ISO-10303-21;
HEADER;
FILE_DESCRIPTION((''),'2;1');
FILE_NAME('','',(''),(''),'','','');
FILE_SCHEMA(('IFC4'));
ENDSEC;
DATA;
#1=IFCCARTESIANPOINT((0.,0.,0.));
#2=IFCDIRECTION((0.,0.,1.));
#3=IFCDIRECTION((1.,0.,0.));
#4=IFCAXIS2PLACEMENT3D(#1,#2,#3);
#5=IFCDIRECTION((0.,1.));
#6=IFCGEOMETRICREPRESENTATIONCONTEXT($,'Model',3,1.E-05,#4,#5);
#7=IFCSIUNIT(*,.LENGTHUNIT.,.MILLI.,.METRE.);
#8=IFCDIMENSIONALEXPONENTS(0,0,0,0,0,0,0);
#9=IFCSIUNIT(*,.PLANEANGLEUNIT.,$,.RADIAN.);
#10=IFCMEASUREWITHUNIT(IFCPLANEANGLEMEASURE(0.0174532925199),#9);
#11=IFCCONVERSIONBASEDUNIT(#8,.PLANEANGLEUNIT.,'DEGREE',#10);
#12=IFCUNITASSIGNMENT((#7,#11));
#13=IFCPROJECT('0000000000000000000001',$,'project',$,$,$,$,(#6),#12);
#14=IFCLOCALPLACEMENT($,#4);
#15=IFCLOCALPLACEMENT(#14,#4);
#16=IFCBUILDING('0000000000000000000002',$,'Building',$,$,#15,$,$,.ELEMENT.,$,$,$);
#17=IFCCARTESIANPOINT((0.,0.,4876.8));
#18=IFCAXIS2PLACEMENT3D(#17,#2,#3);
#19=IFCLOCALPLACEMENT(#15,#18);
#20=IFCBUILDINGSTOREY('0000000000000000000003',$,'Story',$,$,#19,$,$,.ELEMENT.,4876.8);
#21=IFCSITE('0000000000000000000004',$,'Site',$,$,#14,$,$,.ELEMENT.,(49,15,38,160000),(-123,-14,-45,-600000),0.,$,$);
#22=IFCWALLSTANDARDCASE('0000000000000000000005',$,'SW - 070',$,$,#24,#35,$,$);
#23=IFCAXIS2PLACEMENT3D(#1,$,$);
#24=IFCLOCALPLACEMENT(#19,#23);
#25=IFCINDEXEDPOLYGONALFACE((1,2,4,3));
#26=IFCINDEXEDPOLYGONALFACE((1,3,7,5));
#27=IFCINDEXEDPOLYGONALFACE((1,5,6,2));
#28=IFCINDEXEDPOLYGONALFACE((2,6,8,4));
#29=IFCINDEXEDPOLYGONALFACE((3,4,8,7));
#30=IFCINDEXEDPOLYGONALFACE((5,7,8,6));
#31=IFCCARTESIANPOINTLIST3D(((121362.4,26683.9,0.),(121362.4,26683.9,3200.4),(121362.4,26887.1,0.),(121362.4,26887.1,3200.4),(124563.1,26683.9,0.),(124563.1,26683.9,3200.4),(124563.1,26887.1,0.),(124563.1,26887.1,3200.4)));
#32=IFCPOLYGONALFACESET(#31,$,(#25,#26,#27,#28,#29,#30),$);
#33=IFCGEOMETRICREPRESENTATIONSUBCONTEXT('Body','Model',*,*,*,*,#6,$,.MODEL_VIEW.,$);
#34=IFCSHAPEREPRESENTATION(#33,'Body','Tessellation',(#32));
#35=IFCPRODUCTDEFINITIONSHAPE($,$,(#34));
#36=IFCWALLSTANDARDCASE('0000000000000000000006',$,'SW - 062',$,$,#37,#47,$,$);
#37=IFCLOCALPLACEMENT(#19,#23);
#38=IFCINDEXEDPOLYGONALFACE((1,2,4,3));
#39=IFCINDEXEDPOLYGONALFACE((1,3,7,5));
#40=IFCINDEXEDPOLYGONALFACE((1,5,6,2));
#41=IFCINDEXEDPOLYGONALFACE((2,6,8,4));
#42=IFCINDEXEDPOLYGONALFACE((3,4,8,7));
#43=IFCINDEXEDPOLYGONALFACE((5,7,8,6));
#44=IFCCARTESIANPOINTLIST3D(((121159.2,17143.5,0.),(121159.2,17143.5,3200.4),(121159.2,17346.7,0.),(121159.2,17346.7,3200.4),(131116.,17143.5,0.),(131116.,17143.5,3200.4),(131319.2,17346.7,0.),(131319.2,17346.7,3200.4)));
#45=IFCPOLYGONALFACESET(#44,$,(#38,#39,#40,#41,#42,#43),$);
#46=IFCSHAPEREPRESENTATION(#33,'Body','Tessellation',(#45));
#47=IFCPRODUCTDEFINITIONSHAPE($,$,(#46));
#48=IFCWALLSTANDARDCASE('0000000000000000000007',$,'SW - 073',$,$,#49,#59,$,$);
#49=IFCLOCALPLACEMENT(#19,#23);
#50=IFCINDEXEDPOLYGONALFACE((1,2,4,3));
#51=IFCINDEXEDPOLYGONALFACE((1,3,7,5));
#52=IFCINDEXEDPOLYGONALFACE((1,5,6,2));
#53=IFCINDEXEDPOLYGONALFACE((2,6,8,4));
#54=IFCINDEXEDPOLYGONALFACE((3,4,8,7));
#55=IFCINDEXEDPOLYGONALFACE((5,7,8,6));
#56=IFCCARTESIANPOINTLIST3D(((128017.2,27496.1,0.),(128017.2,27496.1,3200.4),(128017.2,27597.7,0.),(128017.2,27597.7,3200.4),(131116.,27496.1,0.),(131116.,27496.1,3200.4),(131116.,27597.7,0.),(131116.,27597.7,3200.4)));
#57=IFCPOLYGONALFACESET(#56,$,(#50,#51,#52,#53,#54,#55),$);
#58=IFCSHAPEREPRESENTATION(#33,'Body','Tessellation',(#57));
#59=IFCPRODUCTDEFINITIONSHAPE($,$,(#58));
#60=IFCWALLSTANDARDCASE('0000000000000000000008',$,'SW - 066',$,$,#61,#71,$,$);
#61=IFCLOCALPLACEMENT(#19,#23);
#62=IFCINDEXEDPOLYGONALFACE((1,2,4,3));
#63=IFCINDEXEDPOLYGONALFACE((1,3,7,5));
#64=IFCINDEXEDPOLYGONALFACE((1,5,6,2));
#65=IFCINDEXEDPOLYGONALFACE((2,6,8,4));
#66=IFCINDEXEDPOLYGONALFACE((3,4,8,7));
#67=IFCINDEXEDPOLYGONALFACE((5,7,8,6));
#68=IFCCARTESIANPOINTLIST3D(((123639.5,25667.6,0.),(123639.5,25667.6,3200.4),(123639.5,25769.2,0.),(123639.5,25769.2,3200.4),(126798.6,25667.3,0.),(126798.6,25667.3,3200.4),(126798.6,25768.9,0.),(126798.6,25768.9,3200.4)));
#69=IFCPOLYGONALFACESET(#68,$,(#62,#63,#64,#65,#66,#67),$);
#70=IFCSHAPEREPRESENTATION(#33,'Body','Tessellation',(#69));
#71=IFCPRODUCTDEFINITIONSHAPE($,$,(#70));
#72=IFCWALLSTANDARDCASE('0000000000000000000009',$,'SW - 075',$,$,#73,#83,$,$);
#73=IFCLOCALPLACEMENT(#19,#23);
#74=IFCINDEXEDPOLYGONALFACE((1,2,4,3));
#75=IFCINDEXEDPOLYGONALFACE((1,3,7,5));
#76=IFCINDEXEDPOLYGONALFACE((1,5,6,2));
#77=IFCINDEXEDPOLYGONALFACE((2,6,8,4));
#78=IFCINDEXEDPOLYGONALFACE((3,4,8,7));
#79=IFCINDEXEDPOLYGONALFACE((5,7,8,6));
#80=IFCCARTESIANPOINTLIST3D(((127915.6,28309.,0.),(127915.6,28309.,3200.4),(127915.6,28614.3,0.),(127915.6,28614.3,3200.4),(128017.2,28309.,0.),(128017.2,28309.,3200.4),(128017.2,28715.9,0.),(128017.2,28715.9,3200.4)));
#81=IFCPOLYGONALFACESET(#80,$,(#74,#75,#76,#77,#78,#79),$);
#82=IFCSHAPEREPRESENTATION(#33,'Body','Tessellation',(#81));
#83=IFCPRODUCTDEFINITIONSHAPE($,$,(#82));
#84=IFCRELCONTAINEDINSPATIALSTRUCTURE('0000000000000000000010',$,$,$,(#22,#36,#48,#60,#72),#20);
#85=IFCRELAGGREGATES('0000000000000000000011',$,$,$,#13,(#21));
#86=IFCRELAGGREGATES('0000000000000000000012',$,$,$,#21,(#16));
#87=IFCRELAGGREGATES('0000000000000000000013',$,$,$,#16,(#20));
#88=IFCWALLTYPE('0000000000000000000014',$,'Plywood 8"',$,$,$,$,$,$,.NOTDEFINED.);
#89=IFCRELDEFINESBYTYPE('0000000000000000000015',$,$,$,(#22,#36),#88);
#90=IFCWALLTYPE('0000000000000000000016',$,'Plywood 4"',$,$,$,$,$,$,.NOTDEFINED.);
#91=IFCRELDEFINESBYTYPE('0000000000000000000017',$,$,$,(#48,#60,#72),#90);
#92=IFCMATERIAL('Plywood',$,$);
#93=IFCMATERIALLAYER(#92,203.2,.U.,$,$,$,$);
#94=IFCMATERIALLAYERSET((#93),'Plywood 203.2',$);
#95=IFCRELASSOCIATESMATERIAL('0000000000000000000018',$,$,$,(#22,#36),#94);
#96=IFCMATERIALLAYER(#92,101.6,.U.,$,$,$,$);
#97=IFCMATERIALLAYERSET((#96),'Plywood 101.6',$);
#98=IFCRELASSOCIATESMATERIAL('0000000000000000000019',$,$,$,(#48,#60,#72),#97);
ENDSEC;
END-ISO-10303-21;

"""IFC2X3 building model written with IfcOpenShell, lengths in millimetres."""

from ifc_helpers import new_model, entity, si_unit, converted_unit, direction, frame, origin_with_axes, place, context, subcontext, project, spatial, polyline, outline, extrude, material, layer, layer_set, layer_usage, type_object, element, save


model = new_model("IFC2X3")

# Units and contexts
model_context = context("Model", 3, precision=1e-05, world=origin_with_axes(), true_north=direction((0.0, 1.0)))
body_context = subcontext(model_context, "Body", "Model", "MODEL_VIEW")
ifc_project = project(units=[si_unit("LENGTHUNIT", "METRE", prefix="MILLI"), converted_unit("PLANEANGLEUNIT", "DEGREE", entity("IfcPlaneAngleMeasure", 0.0174532925199), si_unit("PLANEANGLEUNIT", "RADIAN"), dimensions=[0, 0, 0, 0, 0, 0, 0])], contexts=[model_context])

# Site, building, storey
site_placement = place(None, origin_with_axes())
site = spatial("IfcSite", under=ifc_project, at=site_placement, Name="Site", CompositionType="ELEMENT", RefLatitude=(49, 15, 38, 160000), RefLongitude=(-123, -14, -45, -600000), RefElevation=0.0)
building_placement = place(site_placement, origin_with_axes())
building = spatial("IfcBuilding", under=site, at=building_placement, Name="Building", CompositionType="ELEMENT")
storey_placement = place(building_placement, frame((0.0, 0.0, 4876.8), z_axis=(0.0, 0.0, 1.0), x_axis=(1.0, 0.0, 0.0)))
storey = spatial("IfcBuildingStorey", under=building, at=storey_placement, Name="Story", CompositionType="ELEMENT", Elevation=4876.8)

# Shared definitions
ifc_material_1 = material(Name="Plywood")
ifc_layer_1 = layer(ifc_material_1, 203.2, ventilated="UNKNOWN")
ifc_layer_set_1 = layer_set([ifc_layer_1], Name="Plywood 203.2")
wall_type_1 = type_object("IfcWallType", Name="Plywood 8\"", PredefinedType="NOTDEFINED")

# Walls
ifc_layer_usage_1 = layer_usage(ifc_layer_set_1, "AXIS2", "POSITIVE", 0.0)
wall_1_placement = place(storey_placement, frame((124563.1, 26887.1, 0.0), z_axis=(0.0, 0.0, 1.0), x_axis=(-1.0, 0.0, 0.0)))
element("IfcWallStandardCase", 1, at=wall_1_placement, inside=storey, type_object=wall_type_1, material=ifc_layer_usage_1, Name="SW - 070", context=body_context, shape_type="SweptSolid", body=[
    extrude(outline(polyline([(0.0, 0.0), (3200.6, 0.0), (3200.6, 203.2), (0.0, 203.2), (0.0, 0.0)])), origin_with_axes(), (0.0, 0.0, 1.0), 3200.4),
])
ifc_layer_usage_2 = layer_usage(ifc_layer_set_1, "AXIS2", "POSITIVE", 0.0)
wall_2_placement = place(storey_placement, frame((131116.0, 17346.7, 0.0), z_axis=(0.0, 0.0, 1.0), x_axis=(-1.0, 0.0, 0.0)))
element("IfcWallStandardCase", 2, at=wall_2_placement, inside=storey, type_object=wall_type_1, material=ifc_layer_usage_2, Name="SW - 062", context=body_context, shape_type="SweptSolid", body=[
    extrude(outline(polyline([(-203.2, 0.0), (9956.8, 0.0), (9956.8, 203.2), (0.0, 203.2), (-203.2, 0.0)])), origin_with_axes(), (0.0, 0.0, 1.0), 3200.4),
])

# Shared definitions
ifc_layer_2 = layer(ifc_material_1, 101.6, ventilated="UNKNOWN")
ifc_layer_set_2 = layer_set([ifc_layer_2], Name="Plywood 101.6")
wall_type_2 = type_object("IfcWallType", Name="Plywood 4\"", PredefinedType="NOTDEFINED")

# Walls
ifc_layer_usage_3 = layer_usage(ifc_layer_set_2, "AXIS2", "POSITIVE", 0.0)
wall_3_placement = place(storey_placement, frame((128017.2, 27496.1, 0.0), z_axis=(0.0, 0.0, 1.0), x_axis=(1.0, 0.0, 0.0)))
element("IfcWallStandardCase", 3, at=wall_3_placement, inside=storey, type_object=wall_type_2, material=ifc_layer_usage_3, Name="SW - 073", context=body_context, shape_type="SweptSolid", body=[
    extrude(outline(polyline([(0.0, 0.0), (3098.8, 0.0), (3098.8, 101.6), (0.0, 101.6), (0.0, 0.0)])), origin_with_axes(), (0.0, 0.0, 1.0), 3200.4),
])
ifc_layer_usage_4 = layer_usage(ifc_layer_set_2, "AXIS2", "POSITIVE", 0.0)
wall_4_placement = place(storey_placement, frame((126798.6, 25768.9, 0.0), z_axis=(0.0, 0.0, 1.0), x_axis=(-1.0, 0.000087, 0.0)))
element("IfcWallStandardCase", 4, at=wall_4_placement, inside=storey, type_object=wall_type_2, material=ifc_layer_usage_4, Name="SW - 066", context=body_context, shape_type="SweptSolid", body=[
    extrude(outline(polyline([(0.0, 0.0), (3159.2, 0.0), (3159.2, 101.6), (0.0, 101.6), (0.0, 0.0)])), origin_with_axes(), (0.0, 0.0, 1.0), 3200.4),
])

# Wall
ifc_layer_usage_5 = layer_usage(ifc_layer_set_2, "AXIS2", "POSITIVE", 0.0)
wall_5_placement = place(storey_placement, frame((128017.2, 28309.0, 0.0), z_axis=(0.0, 0.0, 1.0), x_axis=(0.0, 1.0, 0.0)))
element("IfcWallStandardCase", 5, at=wall_5_placement, inside=storey, type_object=wall_type_2, material=ifc_layer_usage_5, Name="SW - 075", context=body_context, shape_type="SweptSolid", body=[
    extrude(outline(polyline([(0.0, 0.0), (406.9, 0.0), (305.3, 101.6), (0.0, 101.6), (0.0, 0.0)])), origin_with_axes(), (0.0, 0.0, 1.0), 3200.4),
])

save(model, "model.ifc")
